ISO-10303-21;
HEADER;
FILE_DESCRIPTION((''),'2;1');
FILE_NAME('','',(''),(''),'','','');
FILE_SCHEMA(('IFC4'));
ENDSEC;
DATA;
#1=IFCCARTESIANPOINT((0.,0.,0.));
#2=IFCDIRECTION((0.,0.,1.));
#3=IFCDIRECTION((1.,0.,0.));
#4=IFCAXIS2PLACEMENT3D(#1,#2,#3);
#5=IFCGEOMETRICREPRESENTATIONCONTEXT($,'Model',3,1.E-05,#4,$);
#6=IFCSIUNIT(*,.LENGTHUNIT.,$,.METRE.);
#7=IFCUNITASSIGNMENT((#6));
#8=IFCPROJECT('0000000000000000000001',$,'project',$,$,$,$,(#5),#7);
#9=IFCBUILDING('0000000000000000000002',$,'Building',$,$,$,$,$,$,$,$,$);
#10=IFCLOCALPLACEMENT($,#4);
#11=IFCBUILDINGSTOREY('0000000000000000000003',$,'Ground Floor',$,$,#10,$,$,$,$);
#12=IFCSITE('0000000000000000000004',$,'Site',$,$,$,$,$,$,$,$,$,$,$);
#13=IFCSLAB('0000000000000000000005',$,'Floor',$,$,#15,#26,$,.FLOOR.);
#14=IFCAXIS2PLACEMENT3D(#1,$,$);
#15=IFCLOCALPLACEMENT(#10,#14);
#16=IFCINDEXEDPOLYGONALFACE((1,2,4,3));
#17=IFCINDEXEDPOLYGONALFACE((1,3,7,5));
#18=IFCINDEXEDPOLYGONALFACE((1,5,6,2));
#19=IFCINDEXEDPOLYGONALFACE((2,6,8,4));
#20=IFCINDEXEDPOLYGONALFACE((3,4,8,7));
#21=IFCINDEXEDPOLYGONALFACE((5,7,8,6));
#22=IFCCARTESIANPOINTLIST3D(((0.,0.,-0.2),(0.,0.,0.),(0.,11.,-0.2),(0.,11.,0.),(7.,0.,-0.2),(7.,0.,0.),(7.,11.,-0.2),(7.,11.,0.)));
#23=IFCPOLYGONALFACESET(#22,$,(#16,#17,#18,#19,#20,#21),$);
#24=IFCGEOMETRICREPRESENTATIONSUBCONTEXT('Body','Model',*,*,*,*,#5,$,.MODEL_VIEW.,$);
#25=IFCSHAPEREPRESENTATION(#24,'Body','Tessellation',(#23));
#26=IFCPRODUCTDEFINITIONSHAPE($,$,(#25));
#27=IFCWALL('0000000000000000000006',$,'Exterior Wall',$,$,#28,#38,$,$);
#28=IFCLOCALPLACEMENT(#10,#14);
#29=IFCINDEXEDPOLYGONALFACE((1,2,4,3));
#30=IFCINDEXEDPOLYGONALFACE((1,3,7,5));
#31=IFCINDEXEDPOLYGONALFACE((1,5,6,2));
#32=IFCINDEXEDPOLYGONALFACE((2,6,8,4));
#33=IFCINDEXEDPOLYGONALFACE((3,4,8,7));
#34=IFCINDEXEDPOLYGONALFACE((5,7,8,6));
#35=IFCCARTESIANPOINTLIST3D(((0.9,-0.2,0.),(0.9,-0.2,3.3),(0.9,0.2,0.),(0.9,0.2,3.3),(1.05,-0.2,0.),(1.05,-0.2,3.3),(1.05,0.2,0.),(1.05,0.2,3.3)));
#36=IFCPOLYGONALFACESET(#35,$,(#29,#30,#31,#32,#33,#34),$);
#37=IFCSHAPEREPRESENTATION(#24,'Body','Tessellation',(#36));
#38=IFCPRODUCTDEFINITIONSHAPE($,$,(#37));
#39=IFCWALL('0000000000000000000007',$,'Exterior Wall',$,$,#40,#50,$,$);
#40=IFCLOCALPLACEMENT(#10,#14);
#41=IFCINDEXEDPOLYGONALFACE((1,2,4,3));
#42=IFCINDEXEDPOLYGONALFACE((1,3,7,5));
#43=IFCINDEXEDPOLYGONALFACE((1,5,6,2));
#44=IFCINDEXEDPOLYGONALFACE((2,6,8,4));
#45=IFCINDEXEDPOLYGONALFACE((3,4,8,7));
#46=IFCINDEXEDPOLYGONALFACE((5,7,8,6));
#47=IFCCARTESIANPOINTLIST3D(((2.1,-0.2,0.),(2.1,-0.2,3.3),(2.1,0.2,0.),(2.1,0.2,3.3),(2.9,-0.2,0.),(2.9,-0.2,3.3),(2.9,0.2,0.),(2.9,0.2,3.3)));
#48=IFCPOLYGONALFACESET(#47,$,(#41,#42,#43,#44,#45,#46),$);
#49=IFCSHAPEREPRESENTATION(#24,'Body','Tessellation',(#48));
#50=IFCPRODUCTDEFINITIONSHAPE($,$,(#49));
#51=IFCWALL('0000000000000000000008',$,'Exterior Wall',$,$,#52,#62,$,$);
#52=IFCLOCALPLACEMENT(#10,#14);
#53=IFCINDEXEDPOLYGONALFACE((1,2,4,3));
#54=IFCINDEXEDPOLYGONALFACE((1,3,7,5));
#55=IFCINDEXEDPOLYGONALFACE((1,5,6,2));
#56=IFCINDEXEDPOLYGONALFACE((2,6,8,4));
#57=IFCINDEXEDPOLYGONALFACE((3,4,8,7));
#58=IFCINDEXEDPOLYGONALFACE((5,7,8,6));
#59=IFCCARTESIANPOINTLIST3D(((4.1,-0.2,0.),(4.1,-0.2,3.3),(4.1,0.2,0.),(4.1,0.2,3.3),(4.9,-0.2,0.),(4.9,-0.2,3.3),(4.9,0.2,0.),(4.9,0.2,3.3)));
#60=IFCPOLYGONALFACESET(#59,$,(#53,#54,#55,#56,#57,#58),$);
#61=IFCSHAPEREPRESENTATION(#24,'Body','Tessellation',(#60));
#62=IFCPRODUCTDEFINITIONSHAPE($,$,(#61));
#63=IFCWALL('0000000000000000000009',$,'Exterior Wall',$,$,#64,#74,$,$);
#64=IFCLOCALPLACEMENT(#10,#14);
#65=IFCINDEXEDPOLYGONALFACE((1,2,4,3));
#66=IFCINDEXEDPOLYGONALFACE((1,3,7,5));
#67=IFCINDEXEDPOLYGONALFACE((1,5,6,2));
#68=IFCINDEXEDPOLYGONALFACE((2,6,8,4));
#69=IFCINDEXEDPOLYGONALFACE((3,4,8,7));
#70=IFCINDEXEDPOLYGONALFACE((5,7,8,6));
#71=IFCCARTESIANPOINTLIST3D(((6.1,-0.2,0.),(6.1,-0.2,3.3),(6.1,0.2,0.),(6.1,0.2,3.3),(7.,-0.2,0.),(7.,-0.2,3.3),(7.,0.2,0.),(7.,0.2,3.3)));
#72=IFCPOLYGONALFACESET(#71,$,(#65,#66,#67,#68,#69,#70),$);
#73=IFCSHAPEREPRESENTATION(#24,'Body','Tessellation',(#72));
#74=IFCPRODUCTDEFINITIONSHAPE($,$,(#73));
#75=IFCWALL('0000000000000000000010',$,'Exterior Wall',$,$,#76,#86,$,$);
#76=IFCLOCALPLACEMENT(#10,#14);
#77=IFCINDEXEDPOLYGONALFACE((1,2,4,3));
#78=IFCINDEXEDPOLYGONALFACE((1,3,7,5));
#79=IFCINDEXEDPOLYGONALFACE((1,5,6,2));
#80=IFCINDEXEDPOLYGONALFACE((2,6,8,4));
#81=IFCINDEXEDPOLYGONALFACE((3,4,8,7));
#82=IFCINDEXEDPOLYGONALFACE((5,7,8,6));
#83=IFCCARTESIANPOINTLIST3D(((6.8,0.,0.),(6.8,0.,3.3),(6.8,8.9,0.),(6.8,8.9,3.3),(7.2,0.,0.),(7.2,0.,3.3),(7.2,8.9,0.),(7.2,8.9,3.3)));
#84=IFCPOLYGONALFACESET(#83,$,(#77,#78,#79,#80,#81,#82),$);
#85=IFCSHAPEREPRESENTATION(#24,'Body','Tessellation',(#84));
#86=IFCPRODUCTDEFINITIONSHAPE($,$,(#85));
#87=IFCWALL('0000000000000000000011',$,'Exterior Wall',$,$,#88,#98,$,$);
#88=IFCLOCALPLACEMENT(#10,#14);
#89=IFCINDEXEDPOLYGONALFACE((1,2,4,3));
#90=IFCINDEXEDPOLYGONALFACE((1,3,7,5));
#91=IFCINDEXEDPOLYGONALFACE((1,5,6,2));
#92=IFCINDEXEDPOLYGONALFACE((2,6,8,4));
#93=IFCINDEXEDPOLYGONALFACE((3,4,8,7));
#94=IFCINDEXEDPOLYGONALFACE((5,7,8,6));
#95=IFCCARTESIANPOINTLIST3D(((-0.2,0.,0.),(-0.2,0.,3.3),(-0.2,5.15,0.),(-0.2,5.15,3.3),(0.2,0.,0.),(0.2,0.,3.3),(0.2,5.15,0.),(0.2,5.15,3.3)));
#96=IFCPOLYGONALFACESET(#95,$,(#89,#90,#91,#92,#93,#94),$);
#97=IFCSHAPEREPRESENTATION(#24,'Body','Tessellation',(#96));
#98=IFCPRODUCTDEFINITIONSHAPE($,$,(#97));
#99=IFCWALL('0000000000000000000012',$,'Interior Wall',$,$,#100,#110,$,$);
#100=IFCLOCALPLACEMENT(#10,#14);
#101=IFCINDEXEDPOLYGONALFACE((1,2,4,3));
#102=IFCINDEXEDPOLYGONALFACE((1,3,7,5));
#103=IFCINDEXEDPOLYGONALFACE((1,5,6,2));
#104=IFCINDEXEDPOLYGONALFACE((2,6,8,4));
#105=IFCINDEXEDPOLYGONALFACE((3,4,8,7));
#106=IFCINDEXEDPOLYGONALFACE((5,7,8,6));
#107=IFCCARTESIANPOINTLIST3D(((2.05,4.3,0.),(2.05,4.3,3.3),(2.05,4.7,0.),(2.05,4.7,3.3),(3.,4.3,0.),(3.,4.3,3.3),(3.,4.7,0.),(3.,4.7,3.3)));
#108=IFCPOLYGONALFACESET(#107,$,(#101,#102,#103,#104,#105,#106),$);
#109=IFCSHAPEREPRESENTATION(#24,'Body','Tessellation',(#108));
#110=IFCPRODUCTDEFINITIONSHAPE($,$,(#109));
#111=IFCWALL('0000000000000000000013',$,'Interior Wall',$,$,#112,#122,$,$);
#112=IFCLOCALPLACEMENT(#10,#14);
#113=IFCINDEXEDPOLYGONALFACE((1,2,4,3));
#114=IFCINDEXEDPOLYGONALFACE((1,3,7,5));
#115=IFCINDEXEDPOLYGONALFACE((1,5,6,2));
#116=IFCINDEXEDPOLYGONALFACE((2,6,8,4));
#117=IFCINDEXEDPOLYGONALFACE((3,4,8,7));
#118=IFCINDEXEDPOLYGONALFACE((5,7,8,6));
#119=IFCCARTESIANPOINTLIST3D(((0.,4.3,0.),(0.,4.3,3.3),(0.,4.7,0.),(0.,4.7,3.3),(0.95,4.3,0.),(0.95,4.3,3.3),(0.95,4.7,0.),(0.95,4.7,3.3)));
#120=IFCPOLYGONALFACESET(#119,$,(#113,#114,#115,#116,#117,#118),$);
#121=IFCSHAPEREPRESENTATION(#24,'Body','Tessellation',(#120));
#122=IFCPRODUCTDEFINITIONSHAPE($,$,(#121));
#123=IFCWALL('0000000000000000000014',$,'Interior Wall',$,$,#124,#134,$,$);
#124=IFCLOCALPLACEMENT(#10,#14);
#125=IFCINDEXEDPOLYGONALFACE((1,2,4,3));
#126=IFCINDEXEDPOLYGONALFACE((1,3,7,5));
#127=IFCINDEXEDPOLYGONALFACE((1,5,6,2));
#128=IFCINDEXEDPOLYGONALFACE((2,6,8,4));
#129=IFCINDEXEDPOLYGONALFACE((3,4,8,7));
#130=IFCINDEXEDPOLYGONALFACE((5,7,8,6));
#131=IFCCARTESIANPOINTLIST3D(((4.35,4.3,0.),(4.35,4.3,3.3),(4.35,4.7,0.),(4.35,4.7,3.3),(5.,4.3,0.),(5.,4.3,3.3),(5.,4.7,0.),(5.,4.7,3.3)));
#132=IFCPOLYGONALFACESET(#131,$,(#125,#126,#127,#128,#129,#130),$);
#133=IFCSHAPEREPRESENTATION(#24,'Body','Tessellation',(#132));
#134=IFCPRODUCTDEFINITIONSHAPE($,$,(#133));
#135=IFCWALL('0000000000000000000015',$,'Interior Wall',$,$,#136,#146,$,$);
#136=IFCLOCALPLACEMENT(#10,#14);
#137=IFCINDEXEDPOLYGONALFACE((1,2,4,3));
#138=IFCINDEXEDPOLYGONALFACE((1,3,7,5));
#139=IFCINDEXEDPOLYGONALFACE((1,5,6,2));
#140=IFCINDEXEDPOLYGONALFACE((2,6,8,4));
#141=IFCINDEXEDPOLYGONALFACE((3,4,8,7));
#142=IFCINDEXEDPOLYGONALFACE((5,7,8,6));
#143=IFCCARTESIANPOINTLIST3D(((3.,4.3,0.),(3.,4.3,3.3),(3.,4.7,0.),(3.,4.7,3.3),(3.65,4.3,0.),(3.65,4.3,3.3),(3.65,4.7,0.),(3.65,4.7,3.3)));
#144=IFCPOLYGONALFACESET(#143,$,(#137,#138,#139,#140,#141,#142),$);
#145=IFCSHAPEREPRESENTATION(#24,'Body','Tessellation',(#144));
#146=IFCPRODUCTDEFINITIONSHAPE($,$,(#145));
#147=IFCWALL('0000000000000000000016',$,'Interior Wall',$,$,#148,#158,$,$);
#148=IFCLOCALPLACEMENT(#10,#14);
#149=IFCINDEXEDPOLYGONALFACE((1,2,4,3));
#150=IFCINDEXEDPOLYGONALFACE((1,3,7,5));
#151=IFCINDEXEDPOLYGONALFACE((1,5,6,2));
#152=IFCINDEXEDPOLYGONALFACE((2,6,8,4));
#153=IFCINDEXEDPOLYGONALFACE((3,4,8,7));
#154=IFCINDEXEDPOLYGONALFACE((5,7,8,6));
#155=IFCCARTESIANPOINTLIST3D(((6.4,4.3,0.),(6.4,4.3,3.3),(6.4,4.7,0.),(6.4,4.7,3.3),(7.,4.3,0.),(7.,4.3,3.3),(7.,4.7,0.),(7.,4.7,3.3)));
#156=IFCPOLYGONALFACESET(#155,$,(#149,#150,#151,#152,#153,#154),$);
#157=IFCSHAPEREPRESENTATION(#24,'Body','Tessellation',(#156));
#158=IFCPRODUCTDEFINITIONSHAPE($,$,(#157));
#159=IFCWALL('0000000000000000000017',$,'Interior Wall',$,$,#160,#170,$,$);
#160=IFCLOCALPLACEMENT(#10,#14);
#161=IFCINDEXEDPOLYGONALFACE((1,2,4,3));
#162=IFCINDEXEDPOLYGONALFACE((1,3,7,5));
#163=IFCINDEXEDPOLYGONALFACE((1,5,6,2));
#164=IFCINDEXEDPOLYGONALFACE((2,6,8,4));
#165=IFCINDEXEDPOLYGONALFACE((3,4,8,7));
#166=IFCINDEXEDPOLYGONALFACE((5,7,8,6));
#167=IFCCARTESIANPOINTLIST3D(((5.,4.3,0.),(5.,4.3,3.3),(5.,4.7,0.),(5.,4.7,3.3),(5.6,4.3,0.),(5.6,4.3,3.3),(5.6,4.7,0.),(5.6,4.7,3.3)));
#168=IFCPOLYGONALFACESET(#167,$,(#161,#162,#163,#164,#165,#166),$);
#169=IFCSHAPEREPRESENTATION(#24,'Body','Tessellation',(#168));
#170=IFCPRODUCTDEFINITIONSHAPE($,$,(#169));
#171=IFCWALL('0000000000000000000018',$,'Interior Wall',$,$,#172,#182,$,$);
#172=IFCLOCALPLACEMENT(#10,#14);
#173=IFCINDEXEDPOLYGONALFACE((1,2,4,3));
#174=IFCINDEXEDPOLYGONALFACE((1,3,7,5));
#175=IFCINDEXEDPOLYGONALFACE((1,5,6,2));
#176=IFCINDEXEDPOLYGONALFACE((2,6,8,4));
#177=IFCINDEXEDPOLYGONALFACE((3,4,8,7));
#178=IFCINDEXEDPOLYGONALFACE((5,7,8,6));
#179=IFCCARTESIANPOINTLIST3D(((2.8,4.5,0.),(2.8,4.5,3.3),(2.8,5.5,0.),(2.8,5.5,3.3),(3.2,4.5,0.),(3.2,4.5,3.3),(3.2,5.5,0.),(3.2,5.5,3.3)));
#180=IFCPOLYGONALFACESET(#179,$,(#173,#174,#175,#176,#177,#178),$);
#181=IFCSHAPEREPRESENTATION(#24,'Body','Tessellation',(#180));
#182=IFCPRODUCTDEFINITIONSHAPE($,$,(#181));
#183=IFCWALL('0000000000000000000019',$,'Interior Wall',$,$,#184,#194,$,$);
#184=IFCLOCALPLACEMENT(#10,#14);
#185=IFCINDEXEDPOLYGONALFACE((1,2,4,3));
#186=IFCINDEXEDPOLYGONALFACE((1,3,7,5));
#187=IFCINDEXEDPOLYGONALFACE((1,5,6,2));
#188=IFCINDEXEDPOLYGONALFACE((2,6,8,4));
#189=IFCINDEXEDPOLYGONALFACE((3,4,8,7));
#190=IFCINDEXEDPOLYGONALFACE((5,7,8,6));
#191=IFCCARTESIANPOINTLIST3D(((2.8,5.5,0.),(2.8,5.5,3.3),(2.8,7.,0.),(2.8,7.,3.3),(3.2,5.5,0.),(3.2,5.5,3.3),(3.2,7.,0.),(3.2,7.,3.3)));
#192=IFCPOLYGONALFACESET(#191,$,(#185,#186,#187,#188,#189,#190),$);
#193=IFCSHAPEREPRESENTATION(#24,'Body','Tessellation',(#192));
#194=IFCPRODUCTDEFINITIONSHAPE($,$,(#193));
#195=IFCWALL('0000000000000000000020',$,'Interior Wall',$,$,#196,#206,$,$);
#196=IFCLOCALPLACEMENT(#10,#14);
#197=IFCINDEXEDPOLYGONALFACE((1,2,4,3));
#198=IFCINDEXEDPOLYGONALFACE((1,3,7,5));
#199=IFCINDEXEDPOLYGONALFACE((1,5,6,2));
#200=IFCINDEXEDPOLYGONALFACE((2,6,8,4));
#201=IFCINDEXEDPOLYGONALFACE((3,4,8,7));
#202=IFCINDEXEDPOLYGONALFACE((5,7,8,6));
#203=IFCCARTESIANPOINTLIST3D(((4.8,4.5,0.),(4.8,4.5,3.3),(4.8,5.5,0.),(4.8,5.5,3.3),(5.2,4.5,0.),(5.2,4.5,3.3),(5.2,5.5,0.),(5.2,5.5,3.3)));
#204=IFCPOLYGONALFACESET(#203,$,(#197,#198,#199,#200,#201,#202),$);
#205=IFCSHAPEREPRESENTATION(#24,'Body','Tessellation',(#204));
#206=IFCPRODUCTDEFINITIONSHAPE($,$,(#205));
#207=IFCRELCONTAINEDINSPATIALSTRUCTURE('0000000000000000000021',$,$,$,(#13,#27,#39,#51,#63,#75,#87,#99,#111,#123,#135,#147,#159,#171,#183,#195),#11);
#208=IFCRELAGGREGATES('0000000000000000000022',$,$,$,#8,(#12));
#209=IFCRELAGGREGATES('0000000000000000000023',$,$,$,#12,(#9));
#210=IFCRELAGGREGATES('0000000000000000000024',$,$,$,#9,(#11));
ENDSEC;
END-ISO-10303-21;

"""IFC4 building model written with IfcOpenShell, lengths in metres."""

from ifc_helpers import new_model, si_unit, frame, origin_with_axes, place, context, subcontext, project, spatial, indexed_curve, outline, extrude, element, save


model = new_model("IFC4")

# Units and contexts
model_context = context("Model", 3, precision=1e-05, world=origin_with_axes())
body_context = subcontext(model_context, "Body", "Model", "MODEL_VIEW")
ifc_project = project(units=[si_unit("LENGTHUNIT", "METRE")], contexts=[model_context])

# Site, building, storey
site = spatial("IfcSite", under=ifc_project, Name="Site")
building = spatial("IfcBuilding", under=site, Name="Building")
storey_placement = place(None, origin_with_axes())
storey = spatial("IfcBuildingStorey", under=building, at=storey_placement, Name="Ground Floor")

# Slab
slab_placement = place(storey_placement, frame((0.0, 0.0, -0.2), z_axis=(0.0, 0.0, 1.0), x_axis=(1.0, 0.0, 0.0)))
element("IfcSlab", 1, at=slab_placement, inside=storey, Name="Floor", PredefinedType="FLOOR", context=body_context, shape_type="SweptSolid", body=[
    extrude(outline(indexed_curve([(0.0, 0.0), (7.0, 0.0), (7.0, 11.0), (0.0, 11.0)])), None, (0.0, 0.0, 1.0), 0.2),
])

# Walls
wall_1_placement = place(storey_placement, frame((1.05, 0.0, 0.0), z_axis=(0.0, 0.0, 1.0), x_axis=(-1.0, 0.0, 0.0)))
element("IfcWall", 2, at=wall_1_placement, inside=storey, Name="Exterior Wall", context=body_context, shape_type="SweptSolid", body=[
    extrude(outline(indexed_curve([(0.0, 0.0), (0.0, 0.4), (0.15, 0.4), (0.15, 0.0), (0.0, 0.0)], self_intersect=False)), frame((0.0, -0.2, 0.0), z_axis=(0.0, 0.0, 1.0), x_axis=(1.0, 0.0, 0.0)), (0.0, 0.0, 1.0), 3.3),
])
wall_2_placement = place(storey_placement, frame((2.1, 0.0, 0.0), z_axis=(0.0, 0.0, 1.0), x_axis=(1.0, 0.0, 0.0)))
element("IfcWall", 3, at=wall_2_placement, inside=storey, Name="Exterior Wall", context=body_context, shape_type="SweptSolid", body=[
    extrude(outline(indexed_curve([(0.0, 0.0), (0.0, 0.4), (0.8, 0.4), (0.8, 0.0), (0.0, 0.0)], self_intersect=False)), frame((0.0, -0.2, 0.0), z_axis=(0.0, 0.0, 1.0), x_axis=(1.0, 0.0, 0.0)), (0.0, 0.0, 1.0), 3.3),
])
wall_3_placement = place(storey_placement, frame((4.1, 0.0, 0.0), z_axis=(0.0, 0.0, 1.0), x_axis=(1.0, 0.0, 0.0)))
element("IfcWall", 4, at=wall_3_placement, inside=storey, Name="Exterior Wall", context=body_context, shape_type="SweptSolid", body=[
    extrude(outline(indexed_curve([(0.0, 0.0), (0.0, 0.4), (0.8, 0.4), (0.8, 0.0), (0.0, 0.0)], self_intersect=False)), frame((0.0, -0.2, 0.0), z_axis=(0.0, 0.0, 1.0), x_axis=(1.0, 0.0, 0.0)), (0.0, 0.0, 1.0), 3.3),
])
wall_4_placement = place(storey_placement, frame((6.1, 0.0, 0.0), z_axis=(0.0, 0.0, 1.0), x_axis=(1.0, 0.0, 0.0)))
element("IfcWall", 5, at=wall_4_placement, inside=storey, Name="Exterior Wall", context=body_context, shape_type="SweptSolid", body=[
    extrude(outline(indexed_curve([(0.0, 0.0), (0.0, 0.4), (0.9, 0.4), (0.9, 0.0), (0.0, 0.0)], self_intersect=False)), frame((0.0, -0.2, 0.0), z_axis=(0.0, 0.0, 1.0), x_axis=(1.0, 0.0, 0.0)), (0.0, 0.0, 1.0), 3.3),
])
wall_5_placement = place(storey_placement, frame((7.0, 0.0, 0.0), z_axis=(0.0, 0.0, 1.0), x_axis=(0.0, 1.0, 0.0)))
element("IfcWall", 6, at=wall_5_placement, inside=storey, Name="Exterior Wall", context=body_context, shape_type="SweptSolid", body=[
    extrude(outline(indexed_curve([(0.0, 0.0), (0.0, 0.4), (8.9, 0.4), (8.9, 0.0), (0.0, 0.0)], self_intersect=False)), frame((0.0, -0.2, 0.0), z_axis=(0.0, 0.0, 1.0), x_axis=(1.0, 0.0, 0.0)), (0.0, 0.0, 1.0), 3.3),
])
wall_6_placement = place(storey_placement, frame((0.0, 5.15, 0.0), z_axis=(0.0, 0.0, 1.0), x_axis=(0.0, -1.0, 0.0)))
element("IfcWall", 7, at=wall_6_placement, inside=storey, Name="Exterior Wall", context=body_context, shape_type="SweptSolid", body=[
    extrude(outline(indexed_curve([(0.0, 0.0), (0.0, 0.4), (5.15, 0.4), (5.15, 0.0), (0.0, 0.0)], self_intersect=False)), frame((0.0, -0.2, 0.0), z_axis=(0.0, 0.0, 1.0), x_axis=(1.0, 0.0, 0.0)), (0.0, 0.0, 1.0), 3.3),
])
for number, where, z_axis, x_axis, name in (
    (8, (3.0, 4.5, 0.0), (0.0, 0.0, 1.0), (-1.0, 0.0, 0.0), "Interior Wall"),
    (9, (0.95, 4.5, 0.0), (0.0, 0.0, 1.0), (-1.0, 0.0, 0.0), "Interior Wall"),
):
    element("IfcWall", number, at=place(storey_placement, frame(where, z_axis=z_axis, x_axis=x_axis)), inside=storey, Name=name, context=body_context, shape_type="SweptSolid", body=[
        extrude(outline(indexed_curve([(0.0, 0.0), (0.0, 0.4), (0.95, 0.4), (0.95, 0.0), (0.0, 0.0)], self_intersect=False)), frame((0.0, -0.2, 0.0), z_axis=(0.0, 0.0, 1.0), x_axis=(1.0, 0.0, 0.0)), (0.0, 0.0, 1.0), 3.3),
    ])
wall_7_placement = place(storey_placement, frame((5.0, 4.5, 0.0), z_axis=(0.0, 0.0, 1.0), x_axis=(-1.0, 0.0, 0.0)))
element("IfcWall", 10, at=wall_7_placement, inside=storey, Name="Interior Wall", context=body_context, shape_type="SweptSolid", body=[
    extrude(outline(indexed_curve([(0.0, 0.0), (0.0, 0.4), (0.65, 0.4), (0.65, 0.0), (0.0, 0.0)], self_intersect=False)), frame((0.0, -0.2, 0.0), z_axis=(0.0, 0.0, 1.0), x_axis=(1.0, 0.0, 0.0)), (0.0, 0.0, 1.0), 3.3),
])
wall_8_placement = place(storey_placement, frame((3.65, 4.5, 0.0), z_axis=(0.0, 0.0, 1.0), x_axis=(-1.0, 0.0, 0.0)))
element("IfcWall", 11, at=wall_8_placement, inside=storey, Name="Interior Wall", context=body_context, shape_type="SweptSolid", body=[
    extrude(outline(indexed_curve([(0.0, 0.0), (0.0, 0.4), (0.65, 0.4), (0.65, 0.0), (0.0, 0.0)], self_intersect=False)), frame((0.0, -0.2, 0.0), z_axis=(0.0, 0.0, 1.0), x_axis=(1.0, 0.0, 0.0)), (0.0, 0.0, 1.0), 3.3),
])
for number, where, z_axis, x_axis, name in (
    (12, (7.0, 4.5, 0.0), (0.0, 0.0, 1.0), (-1.0, 0.0, 0.0), "Interior Wall"),
    (13, (5.6, 4.5, 0.0), (0.0, 0.0, 1.0), (-1.0, 0.0, 0.0), "Interior Wall"),
):
    element("IfcWall", number, at=place(storey_placement, frame(where, z_axis=z_axis, x_axis=x_axis)), inside=storey, Name=name, context=body_context, shape_type="SweptSolid", body=[
        extrude(outline(indexed_curve([(0.0, 0.0), (0.0, 0.4), (0.6, 0.4), (0.6, 0.0), (0.0, 0.0)], self_intersect=False)), frame((0.0, -0.2, 0.0), z_axis=(0.0, 0.0, 1.0), x_axis=(1.0, 0.0, 0.0)), (0.0, 0.0, 1.0), 3.3),
    ])
wall_9_placement = place(storey_placement, frame((3.0, 4.5, 0.0), z_axis=(0.0, 0.0, 1.0), x_axis=(0.0, 1.0, 0.0)))
element("IfcWall", 14, at=wall_9_placement, inside=storey, Name="Interior Wall", context=body_context, shape_type="SweptSolid", body=[
    extrude(outline(indexed_curve([(0.0, 0.0), (0.0, 0.4), (1.0, 0.4), (1.0, 0.0), (0.0, 0.0)], self_intersect=False)), frame((0.0, -0.2, 0.0), z_axis=(0.0, 0.0, 1.0), x_axis=(1.0, 0.0, 0.0)), (0.0, 0.0, 1.0), 3.3),
])
wall_10_placement = place(storey_placement, frame((3.0, 5.5, 0.0), z_axis=(0.0, 0.0, 1.0), x_axis=(0.0, 1.0, 0.0)))
element("IfcWall", 15, at=wall_10_placement, inside=storey, Name="Interior Wall", context=body_context, shape_type="SweptSolid", body=[
    extrude(outline(indexed_curve([(0.0, 0.0), (0.0, 0.4), (1.5, 0.4), (1.5, 0.0), (0.0, 0.0)], self_intersect=False)), frame((0.0, -0.2, 0.0), z_axis=(0.0, 0.0, 1.0), x_axis=(1.0, 0.0, 0.0)), (0.0, 0.0, 1.0), 3.3),
])
wall_11_placement = place(storey_placement, frame((5.0, 4.5, 0.0), z_axis=(0.0, 0.0, 1.0), x_axis=(0.0, 1.0, 0.0)))
element("IfcWall", 16, at=wall_11_placement, inside=storey, Name="Interior Wall", context=body_context, shape_type="SweptSolid", body=[
    extrude(outline(indexed_curve([(0.0, 0.0), (0.0, 0.4), (1.0, 0.4), (1.0, 0.0), (0.0, 0.0)], self_intersect=False)), frame((0.0, -0.2, 0.0), z_axis=(0.0, 0.0, 1.0), x_axis=(1.0, 0.0, 0.0)), (0.0, 0.0, 1.0), 3.3),
])

save(model, "model.ifc")
